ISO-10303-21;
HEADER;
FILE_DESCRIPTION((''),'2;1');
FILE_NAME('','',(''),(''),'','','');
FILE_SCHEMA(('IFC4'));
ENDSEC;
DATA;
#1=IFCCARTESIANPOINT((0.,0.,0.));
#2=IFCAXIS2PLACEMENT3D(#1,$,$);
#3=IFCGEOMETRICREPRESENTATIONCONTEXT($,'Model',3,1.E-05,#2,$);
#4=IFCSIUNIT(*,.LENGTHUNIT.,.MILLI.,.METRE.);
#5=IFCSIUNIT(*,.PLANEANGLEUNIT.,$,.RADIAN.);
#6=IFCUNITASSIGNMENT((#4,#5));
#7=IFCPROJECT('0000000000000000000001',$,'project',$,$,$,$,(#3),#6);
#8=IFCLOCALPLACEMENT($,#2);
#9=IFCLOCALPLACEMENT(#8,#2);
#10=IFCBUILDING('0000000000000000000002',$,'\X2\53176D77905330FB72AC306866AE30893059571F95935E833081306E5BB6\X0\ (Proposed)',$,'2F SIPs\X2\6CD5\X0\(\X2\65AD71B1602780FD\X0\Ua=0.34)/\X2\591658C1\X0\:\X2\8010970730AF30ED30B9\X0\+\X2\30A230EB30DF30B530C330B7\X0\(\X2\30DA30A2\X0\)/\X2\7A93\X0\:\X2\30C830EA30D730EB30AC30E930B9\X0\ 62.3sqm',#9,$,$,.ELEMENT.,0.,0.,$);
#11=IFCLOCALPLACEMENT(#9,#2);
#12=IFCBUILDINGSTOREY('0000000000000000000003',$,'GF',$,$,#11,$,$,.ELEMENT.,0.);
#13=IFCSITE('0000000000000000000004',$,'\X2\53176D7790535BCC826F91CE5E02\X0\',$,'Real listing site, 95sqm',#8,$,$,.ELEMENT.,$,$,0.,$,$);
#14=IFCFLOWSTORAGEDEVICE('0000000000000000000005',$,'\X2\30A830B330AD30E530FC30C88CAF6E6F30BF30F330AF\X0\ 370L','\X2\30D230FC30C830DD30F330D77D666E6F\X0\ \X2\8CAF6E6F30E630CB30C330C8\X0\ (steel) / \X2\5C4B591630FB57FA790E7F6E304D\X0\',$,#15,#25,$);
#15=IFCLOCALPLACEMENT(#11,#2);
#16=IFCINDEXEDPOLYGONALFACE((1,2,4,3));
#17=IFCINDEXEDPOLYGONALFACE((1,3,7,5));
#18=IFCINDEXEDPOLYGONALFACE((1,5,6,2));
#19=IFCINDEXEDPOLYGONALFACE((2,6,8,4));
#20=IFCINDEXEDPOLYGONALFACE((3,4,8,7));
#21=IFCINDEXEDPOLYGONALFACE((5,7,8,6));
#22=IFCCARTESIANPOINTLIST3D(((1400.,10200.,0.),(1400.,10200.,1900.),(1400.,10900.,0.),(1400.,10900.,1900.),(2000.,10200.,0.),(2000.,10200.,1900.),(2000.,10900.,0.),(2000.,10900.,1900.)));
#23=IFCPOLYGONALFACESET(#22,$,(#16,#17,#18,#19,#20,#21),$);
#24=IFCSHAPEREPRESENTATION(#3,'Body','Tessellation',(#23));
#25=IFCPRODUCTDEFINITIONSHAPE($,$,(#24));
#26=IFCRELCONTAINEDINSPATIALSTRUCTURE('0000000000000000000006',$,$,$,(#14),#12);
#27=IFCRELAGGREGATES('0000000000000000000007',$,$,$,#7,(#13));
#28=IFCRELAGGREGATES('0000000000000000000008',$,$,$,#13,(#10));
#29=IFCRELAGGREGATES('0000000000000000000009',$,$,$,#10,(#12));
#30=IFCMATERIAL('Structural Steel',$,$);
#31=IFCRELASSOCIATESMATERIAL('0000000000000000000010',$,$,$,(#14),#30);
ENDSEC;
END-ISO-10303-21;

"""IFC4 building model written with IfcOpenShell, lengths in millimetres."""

from ifc_helpers import new_model, si_unit, frame, frame_2d, origin, place, context, project, spatial, rectangle, extrude, material, element, save


model = new_model("IFC4")

# Units and contexts
model_context = context("Model", 3, precision=1e-05, world=origin())
ifc_project = project(units=[si_unit("LENGTHUNIT", "METRE", prefix="MILLI"), si_unit("PLANEANGLEUNIT", "RADIAN")], contexts=[model_context])

# Site, building, storey
site_placement = place(None, origin())
site = spatial("IfcSite", under=ifc_project, at=site_placement, Name="北海道富良野市", ObjectType="Real listing site, 95sqm", CompositionType="ELEMENT", RefElevation=0.0)
building_placement = place(site_placement, origin())
building = spatial("IfcBuilding", under=site, at=building_placement, Name="北海道・犬と暮らす土間広めの家 (Proposed)", ObjectType="2F SIPs法(断熱性能Ua=0.34)/外壁:耐震クロス+アルミサッシ(ペア)/窓:トリプルガラス 62.3sqm", CompositionType="ELEMENT", ElevationOfRefHeight=0.0, ElevationOfTerrain=0.0)
storey_placement = place(building_placement, origin())
storey = spatial("IfcBuildingStorey", under=building, at=storey_placement, Name="GF", CompositionType="ELEMENT", Elevation=0.0)

# Flow storage device
ifc_material_1 = material(Name="Structural Steel")
flow_storage_device_placement = place(storey_placement, frame((700.0, 5100.0, 0.0)))
element("IfcFlowStorageDevice", 1, at=flow_storage_device_placement, inside=storey, material=ifc_material_1, Name="エコキュート貯湯タンク 370L", Description="ヒートポンプ給湯 貯湯ユニット (steel) / 屋外・基礎置き", context=model_context, shape_type="SweptSolid", body=[
    extrude(rectangle(XDim=600.0, YDim=700.0, at=frame_2d((300.0, 350.0))), frame((700.0, 5100.0, 0.0)), (0.0, 0.0, 1.0), 1900.0),
])

save(model, "model.ifc")
